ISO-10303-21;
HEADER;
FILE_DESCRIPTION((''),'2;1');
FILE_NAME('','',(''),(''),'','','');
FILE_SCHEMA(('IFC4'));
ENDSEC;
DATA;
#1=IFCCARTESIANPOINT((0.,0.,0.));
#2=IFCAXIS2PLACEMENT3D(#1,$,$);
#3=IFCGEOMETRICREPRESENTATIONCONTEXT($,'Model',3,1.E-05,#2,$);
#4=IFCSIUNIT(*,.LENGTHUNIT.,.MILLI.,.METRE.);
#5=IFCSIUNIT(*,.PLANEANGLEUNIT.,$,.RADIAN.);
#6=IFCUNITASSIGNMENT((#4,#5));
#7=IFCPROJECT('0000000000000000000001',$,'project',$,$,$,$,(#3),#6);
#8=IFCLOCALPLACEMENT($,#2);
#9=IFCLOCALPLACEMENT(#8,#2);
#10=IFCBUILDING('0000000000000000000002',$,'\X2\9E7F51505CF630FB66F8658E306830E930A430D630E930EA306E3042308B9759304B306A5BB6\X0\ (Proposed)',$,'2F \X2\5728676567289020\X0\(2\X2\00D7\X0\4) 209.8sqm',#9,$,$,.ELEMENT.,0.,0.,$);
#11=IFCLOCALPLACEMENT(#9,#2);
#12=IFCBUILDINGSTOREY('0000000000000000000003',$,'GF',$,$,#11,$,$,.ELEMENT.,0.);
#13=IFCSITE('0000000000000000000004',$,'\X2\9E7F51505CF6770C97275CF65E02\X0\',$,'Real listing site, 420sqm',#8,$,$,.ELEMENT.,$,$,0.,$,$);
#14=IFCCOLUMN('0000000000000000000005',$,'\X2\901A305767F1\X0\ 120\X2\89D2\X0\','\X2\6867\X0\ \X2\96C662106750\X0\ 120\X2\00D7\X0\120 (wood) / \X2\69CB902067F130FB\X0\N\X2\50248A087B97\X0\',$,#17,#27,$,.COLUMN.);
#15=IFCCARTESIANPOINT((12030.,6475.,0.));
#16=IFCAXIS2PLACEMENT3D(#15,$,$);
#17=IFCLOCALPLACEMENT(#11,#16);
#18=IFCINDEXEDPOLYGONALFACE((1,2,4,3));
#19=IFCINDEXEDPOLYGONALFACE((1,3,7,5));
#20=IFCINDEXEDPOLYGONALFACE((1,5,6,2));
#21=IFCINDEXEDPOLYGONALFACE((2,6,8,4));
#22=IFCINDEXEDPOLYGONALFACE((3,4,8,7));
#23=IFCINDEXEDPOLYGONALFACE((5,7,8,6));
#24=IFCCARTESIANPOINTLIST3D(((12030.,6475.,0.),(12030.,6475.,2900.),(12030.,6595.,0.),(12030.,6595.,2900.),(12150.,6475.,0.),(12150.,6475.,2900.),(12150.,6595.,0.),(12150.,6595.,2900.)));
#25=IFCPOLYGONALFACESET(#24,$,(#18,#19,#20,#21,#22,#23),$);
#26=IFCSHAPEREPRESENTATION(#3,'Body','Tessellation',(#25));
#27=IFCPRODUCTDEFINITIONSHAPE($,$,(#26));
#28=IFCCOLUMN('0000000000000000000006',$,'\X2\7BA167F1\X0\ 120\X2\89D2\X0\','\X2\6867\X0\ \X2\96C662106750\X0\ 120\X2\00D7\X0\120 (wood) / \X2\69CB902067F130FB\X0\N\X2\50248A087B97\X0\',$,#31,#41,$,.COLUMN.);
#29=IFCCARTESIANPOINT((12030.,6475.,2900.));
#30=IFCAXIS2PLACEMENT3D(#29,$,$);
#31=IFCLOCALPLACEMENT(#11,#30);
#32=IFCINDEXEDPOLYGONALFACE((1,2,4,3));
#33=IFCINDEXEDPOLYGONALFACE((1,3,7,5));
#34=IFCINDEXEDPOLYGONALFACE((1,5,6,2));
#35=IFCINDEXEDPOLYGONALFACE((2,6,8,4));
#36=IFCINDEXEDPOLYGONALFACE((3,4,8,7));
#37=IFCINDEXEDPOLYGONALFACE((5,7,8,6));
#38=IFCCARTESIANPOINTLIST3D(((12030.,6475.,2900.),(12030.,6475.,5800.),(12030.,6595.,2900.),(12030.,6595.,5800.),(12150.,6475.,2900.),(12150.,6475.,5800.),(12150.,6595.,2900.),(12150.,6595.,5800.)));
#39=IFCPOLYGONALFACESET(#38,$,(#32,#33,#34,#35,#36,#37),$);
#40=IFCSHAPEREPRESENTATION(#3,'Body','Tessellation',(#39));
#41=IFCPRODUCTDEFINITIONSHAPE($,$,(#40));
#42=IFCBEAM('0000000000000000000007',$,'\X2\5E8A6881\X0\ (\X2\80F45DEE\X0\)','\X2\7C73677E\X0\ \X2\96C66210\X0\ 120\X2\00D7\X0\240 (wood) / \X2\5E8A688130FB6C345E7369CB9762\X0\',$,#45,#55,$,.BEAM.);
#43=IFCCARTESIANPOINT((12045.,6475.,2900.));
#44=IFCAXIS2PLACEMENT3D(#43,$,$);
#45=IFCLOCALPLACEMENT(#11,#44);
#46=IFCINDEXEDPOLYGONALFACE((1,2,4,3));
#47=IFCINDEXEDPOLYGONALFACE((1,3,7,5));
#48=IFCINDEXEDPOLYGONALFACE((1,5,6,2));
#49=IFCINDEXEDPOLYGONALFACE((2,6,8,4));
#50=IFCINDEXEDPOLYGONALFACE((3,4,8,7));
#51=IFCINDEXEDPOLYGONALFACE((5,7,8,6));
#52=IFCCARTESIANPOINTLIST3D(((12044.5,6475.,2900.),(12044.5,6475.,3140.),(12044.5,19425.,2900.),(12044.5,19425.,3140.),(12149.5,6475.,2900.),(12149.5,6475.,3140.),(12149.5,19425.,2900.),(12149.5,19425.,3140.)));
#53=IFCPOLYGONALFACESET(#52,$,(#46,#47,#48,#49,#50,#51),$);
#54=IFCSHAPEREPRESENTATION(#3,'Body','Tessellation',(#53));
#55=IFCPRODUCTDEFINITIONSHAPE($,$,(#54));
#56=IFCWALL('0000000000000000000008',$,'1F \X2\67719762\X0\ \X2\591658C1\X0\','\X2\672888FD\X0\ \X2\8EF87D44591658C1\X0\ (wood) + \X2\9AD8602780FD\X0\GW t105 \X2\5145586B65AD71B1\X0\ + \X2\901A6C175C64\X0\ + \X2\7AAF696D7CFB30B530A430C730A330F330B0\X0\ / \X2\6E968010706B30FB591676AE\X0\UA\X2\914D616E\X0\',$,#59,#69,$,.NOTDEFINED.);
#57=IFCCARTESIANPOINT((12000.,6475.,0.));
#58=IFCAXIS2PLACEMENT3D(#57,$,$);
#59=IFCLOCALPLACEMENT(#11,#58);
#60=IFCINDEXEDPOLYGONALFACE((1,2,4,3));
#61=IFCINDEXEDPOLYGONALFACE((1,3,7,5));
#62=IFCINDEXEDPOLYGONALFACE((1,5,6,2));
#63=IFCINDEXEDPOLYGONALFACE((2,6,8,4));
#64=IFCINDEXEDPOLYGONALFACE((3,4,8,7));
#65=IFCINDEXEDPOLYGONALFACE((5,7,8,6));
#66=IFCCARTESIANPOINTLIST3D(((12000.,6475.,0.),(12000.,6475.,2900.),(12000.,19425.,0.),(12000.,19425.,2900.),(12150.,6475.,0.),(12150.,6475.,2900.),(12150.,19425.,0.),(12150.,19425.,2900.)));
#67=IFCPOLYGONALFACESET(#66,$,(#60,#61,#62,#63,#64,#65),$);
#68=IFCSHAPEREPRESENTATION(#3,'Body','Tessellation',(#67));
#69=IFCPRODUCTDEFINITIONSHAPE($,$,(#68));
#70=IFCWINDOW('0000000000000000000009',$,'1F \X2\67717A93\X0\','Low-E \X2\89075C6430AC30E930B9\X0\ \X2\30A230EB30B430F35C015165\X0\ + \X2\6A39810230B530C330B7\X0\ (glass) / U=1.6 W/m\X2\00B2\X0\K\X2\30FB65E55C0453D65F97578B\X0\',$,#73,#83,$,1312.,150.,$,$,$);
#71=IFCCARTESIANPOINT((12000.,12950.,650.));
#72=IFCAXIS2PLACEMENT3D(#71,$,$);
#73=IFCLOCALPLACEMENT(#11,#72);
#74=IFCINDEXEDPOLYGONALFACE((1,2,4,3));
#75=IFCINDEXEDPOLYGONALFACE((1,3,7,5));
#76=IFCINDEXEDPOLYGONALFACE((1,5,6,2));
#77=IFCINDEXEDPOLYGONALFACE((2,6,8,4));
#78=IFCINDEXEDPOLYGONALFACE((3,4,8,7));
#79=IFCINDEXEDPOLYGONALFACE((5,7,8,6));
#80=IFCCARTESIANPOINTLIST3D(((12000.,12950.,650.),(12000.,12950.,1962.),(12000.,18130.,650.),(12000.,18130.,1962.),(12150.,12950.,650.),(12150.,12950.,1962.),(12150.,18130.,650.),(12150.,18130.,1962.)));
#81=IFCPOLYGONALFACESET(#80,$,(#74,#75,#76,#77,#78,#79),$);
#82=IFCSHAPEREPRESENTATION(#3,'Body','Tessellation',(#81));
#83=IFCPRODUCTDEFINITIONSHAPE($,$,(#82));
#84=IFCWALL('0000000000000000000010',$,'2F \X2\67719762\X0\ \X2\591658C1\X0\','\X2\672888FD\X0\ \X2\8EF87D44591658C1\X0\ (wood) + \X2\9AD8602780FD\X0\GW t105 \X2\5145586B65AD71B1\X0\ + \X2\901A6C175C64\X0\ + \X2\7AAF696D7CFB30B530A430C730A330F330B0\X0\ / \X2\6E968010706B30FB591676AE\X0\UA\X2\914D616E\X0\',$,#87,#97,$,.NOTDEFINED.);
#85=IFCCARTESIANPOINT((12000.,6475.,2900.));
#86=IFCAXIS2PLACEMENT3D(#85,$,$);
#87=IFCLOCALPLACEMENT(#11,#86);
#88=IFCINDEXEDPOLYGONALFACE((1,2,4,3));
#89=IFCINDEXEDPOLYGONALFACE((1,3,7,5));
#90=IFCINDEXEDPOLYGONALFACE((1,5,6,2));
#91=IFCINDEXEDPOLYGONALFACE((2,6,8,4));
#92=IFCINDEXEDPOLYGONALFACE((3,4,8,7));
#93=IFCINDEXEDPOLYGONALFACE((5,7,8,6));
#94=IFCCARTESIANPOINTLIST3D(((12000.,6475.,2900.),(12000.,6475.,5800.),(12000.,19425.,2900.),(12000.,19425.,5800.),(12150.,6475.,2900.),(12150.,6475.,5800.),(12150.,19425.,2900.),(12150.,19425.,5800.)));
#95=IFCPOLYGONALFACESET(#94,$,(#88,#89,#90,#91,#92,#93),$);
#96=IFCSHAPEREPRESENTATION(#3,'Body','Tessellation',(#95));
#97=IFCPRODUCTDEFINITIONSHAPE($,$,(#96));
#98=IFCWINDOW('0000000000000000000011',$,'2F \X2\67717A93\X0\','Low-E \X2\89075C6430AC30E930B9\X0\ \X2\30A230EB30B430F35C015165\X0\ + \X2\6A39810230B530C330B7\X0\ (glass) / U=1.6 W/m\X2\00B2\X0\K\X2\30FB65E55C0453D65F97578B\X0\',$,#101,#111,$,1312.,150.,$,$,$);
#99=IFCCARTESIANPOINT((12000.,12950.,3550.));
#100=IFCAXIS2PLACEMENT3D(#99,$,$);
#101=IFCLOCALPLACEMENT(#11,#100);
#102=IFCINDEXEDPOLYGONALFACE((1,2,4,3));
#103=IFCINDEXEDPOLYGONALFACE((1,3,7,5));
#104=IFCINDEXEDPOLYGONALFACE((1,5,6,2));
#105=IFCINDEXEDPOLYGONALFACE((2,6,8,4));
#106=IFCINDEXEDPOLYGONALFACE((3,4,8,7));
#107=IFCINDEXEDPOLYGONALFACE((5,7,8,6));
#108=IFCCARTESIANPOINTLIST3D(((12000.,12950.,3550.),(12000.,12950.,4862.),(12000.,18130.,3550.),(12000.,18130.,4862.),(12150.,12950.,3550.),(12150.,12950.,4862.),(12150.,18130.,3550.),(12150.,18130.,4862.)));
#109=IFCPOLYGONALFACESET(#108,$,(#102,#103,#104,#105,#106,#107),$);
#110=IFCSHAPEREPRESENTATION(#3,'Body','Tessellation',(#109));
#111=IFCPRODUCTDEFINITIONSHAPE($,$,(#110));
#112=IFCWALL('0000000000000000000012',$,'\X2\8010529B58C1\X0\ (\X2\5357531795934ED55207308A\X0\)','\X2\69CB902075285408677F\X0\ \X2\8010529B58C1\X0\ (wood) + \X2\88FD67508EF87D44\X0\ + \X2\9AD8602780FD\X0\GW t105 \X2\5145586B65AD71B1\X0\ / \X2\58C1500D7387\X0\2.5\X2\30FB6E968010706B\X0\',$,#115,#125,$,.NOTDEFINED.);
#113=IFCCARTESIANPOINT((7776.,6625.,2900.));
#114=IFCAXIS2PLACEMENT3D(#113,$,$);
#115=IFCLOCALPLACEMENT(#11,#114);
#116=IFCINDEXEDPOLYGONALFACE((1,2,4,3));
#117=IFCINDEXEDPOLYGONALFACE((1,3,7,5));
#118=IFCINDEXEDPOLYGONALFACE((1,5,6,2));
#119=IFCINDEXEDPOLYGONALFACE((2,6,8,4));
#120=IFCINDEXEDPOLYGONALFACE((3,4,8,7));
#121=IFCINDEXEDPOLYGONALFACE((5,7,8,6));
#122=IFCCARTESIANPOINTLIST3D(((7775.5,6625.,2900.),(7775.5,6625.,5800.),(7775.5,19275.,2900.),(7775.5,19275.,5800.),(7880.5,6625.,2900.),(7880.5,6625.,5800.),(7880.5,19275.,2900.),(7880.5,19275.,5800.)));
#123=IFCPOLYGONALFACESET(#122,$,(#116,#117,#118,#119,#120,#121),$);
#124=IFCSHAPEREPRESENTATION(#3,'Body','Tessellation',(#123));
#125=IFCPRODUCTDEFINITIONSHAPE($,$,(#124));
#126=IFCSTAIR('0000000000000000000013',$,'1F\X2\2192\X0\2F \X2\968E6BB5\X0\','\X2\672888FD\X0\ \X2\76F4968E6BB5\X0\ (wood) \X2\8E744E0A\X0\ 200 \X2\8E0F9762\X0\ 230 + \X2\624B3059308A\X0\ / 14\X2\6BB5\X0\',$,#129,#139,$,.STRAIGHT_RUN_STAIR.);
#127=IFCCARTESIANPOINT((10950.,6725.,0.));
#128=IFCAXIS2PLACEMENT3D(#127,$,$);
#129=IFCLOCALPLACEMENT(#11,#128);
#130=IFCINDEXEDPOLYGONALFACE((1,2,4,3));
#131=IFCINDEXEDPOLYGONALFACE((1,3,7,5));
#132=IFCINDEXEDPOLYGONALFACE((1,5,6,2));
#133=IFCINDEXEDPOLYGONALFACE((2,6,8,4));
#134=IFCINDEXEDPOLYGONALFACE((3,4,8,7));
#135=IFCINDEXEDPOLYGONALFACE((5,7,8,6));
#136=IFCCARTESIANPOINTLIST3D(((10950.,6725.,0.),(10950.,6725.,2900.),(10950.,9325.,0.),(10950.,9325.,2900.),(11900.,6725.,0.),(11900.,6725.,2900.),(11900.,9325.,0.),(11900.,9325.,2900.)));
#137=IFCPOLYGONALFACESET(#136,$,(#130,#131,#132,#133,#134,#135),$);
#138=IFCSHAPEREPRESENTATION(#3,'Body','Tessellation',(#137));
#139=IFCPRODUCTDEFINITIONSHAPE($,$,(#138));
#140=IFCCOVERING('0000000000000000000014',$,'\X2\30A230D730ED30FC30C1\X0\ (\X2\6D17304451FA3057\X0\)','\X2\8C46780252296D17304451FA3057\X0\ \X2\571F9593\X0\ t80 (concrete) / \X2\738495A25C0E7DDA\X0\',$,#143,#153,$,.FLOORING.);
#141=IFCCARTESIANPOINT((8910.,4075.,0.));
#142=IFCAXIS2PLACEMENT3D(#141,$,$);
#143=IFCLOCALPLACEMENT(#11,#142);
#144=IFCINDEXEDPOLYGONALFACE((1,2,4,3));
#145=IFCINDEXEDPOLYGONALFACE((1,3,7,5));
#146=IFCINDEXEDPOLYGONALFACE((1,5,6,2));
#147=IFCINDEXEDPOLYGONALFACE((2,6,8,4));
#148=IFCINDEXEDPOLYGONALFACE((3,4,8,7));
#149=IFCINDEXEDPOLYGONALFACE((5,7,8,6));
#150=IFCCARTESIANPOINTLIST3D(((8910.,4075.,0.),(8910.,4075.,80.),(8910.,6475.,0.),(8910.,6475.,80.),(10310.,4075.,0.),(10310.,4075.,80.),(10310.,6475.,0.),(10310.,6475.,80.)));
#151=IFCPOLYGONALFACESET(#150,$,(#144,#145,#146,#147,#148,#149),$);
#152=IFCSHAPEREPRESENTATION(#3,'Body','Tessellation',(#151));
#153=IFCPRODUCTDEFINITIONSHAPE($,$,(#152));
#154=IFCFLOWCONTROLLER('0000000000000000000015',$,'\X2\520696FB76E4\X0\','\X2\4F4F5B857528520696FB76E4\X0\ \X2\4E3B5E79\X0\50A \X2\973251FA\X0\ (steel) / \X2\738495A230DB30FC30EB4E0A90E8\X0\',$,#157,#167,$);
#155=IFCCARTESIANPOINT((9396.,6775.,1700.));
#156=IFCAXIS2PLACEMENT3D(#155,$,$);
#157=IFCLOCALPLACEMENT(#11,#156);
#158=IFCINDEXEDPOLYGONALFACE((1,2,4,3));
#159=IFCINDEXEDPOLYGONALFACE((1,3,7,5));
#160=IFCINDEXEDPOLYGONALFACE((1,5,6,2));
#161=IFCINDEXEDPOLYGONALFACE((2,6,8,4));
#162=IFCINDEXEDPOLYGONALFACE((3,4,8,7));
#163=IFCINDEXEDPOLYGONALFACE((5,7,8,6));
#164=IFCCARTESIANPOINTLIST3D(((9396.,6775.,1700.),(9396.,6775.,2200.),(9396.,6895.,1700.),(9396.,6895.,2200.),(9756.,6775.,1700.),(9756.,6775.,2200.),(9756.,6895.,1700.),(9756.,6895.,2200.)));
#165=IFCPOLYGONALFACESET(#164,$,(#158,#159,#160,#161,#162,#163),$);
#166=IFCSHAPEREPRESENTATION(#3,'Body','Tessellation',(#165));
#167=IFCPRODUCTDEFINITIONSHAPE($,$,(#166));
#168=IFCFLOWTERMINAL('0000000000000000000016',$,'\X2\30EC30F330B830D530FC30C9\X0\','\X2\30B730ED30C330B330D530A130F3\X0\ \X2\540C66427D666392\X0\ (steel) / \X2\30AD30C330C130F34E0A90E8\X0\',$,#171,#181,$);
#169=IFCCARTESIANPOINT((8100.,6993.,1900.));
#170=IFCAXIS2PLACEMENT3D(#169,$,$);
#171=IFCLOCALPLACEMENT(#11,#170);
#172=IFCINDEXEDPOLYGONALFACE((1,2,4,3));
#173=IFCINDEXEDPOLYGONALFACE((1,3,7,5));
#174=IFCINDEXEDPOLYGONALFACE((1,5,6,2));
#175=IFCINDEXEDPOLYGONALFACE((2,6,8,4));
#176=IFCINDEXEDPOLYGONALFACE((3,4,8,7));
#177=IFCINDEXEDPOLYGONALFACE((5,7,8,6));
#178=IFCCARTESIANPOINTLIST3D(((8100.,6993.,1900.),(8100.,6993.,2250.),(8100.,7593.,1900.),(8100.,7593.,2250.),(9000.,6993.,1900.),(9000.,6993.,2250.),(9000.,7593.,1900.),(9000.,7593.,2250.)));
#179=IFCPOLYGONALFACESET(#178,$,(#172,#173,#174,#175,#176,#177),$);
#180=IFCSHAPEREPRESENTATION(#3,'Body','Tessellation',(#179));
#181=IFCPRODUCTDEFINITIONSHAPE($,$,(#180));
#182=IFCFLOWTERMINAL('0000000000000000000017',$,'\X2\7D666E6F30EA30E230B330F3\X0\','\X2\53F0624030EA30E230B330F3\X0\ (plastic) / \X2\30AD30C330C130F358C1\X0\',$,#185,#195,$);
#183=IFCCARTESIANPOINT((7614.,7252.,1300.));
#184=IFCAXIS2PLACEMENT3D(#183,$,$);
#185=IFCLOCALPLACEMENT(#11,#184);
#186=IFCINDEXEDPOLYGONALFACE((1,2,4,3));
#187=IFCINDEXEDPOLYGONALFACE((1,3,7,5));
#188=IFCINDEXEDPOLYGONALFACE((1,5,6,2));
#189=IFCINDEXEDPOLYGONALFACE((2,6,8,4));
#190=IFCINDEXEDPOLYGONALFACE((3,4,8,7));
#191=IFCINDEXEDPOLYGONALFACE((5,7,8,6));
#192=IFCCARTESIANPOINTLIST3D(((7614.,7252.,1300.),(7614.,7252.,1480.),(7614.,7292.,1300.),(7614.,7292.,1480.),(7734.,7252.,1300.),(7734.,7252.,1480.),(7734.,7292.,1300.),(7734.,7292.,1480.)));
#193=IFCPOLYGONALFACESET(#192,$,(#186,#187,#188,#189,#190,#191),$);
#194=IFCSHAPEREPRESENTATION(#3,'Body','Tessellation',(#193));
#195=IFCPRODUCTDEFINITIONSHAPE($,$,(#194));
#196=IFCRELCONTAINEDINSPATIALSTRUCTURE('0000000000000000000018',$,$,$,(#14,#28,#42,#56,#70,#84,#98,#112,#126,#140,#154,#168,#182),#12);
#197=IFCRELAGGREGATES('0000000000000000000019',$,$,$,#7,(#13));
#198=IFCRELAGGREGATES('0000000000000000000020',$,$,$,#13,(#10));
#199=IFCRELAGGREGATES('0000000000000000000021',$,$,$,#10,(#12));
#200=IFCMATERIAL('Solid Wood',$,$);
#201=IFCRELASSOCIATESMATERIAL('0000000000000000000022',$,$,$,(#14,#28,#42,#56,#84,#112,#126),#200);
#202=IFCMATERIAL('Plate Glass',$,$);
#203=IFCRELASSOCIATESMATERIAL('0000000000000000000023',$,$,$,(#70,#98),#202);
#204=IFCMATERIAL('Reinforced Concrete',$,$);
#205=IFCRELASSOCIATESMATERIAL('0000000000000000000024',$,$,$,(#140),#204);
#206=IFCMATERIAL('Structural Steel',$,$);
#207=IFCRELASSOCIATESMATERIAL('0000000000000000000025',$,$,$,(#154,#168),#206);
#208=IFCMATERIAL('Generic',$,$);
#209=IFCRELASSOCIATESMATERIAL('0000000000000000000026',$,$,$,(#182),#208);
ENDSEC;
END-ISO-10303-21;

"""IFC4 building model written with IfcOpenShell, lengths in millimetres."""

from ifc_helpers import new_model, si_unit, frame, frame_2d, origin, place, context, project, spatial, rectangle, extrude, material, element, fill, save


model = new_model("IFC4")

# Units and contexts
model_context = context("Model", 3, precision=1e-05, world=origin())
ifc_project = project(units=[si_unit("LENGTHUNIT", "METRE", prefix="MILLI"), si_unit("PLANEANGLEUNIT", "RADIAN")], contexts=[model_context])

# Site, building, storey
site_placement = place(None, origin())
site = spatial("IfcSite", under=ifc_project, at=site_placement, Name="鹿児島県霧島市", ObjectType="Real listing site, 420sqm", CompositionType="ELEMENT", RefElevation=0.0)
building_placement = place(site_placement, origin())
building = spatial("IfcBuilding", under=site, at=building_placement, Name="鹿児島・書斎とライブラリのある静かな家 (Proposed)", ObjectType="2F 在来木造(2×4) 209.8sqm", CompositionType="ELEMENT", ElevationOfRefHeight=0.0, ElevationOfTerrain=0.0)
storey_placement = place(building_placement, origin())
storey = spatial("IfcBuildingStorey", under=building, at=storey_placement, Name="GF", CompositionType="ELEMENT", Elevation=0.0)

# Columns
ifc_material_1 = material(Name="Solid Wood")
column_1_placement = place(storey_placement, frame((12030.0, 6475.0, 0.0)))
element("IfcColumn", 1, at=column_1_placement, inside=storey, material=ifc_material_1, Name="通し柱 120角", Description="桧 集成材 120×120 (wood) / 構造柱・N値計算", PredefinedType="COLUMN", context=model_context, shape_type="SweptSolid", body=[
    extrude(rectangle(XDim=120.0, YDim=120.0, at=frame_2d((60.0, 60.0))), frame((12030.0, 6475.0, 0.0)), (0.0, 0.0, 1.0), 2900.0),
])
column_2_placement = place(storey_placement, frame((12030.0, 6475.0, 2900.0)))
element("IfcColumn", 2, at=column_2_placement, inside=storey, material=ifc_material_1, Name="管柱 120角", Description="桧 集成材 120×120 (wood) / 構造柱・N値計算", PredefinedType="COLUMN", context=model_context, shape_type="SweptSolid", body=[
    extrude(rectangle(XDim=120.0, YDim=120.0, at=frame_2d((60.0, 60.0))), frame((12030.0, 6475.0, 2900.0)), (0.0, 0.0, 1.0), 2900.0),
])

# Beam
beam_1_placement = place(storey_placement, frame((12045.0, 6475.0, 2900.0)))
element("IfcBeam", 3, at=beam_1_placement, inside=storey, material=ifc_material_1, Name="床梁 (胴差)", Description="米松 集成 120×240 (wood) / 床梁・水平構面", PredefinedType="BEAM", context=model_context, shape_type="SweptSolid", body=[
    extrude(rectangle(XDim=105.0, YDim=12950.0, at=frame_2d((52.0, 6475.0))), frame((12045.0, 6475.0, 2900.0)), (0.0, 0.0, 1.0), 240.0),
])

# Wall, opening, window
wall_1_placement = place(storey_placement, frame((12000.0, 6475.0, 0.0)))
wall_1 = element("IfcWall", 4, at=wall_1_placement, inside=storey, material=ifc_material_1, Name="1F 東面 外壁", Description="木製 軸組外壁 (wood) + 高性能GW t105 充填断熱 + 通気層 + 窯業系サイディング / 準耐火・外皮UA配慮", PredefinedType="NOTDEFINED", context=model_context, shape_type="SweptSolid", body=[
    extrude(rectangle(XDim=150.0, YDim=12950.0, at=frame_2d((75.0, 6475.0))), frame((12000.0, 6475.0, 0.0)), (0.0, 0.0, 1.0), 2900.0),
])
opening_1_placement = place(storey_placement, frame((12000.0, 12950.0, 650.0)))
opening_1 = element("IfcOpeningElement", 5, at=opening_1_placement, cuts=wall_1, PredefinedType="NOTDEFINED", context=model_context, shape_type="SweptSolid", body=[
    extrude(rectangle(XDim=150.0, YDim=5180.0, at=frame_2d((75.0, 2590.0))), frame((12000.0, 12950.0, 650.0)), (0.0, 0.0, 1.0), 1312.0),
])
ifc_material_2 = material(Name="Plate Glass")
window_1_placement = place(storey_placement, frame((12000.0, 12950.0, 650.0)))
window_1 = element("IfcWindow", 6, at=window_1_placement, inside=storey, material=ifc_material_2, Name="1F 東窓", Description="Low-E 複層ガラス アルゴン封入 + 樹脂サッシ (glass) / U=1.6 W/m²K・日射取得型", OverallHeight=1312.0, OverallWidth=150.0, context=model_context, shape_type="SweptSolid", body=[
    extrude(rectangle(XDim=150.0, YDim=5180.0, at=frame_2d((75.0, 2590.0))), frame((12000.0, 12950.0, 650.0)), (0.0, 0.0, 1.0), 1312.0),
])
fill(opening_1, window_1)

# Wall, opening, window
wall_2_placement = place(storey_placement, frame((12000.0, 6475.0, 2900.0)))
wall_2 = element("IfcWall", 7, at=wall_2_placement, inside=storey, material=ifc_material_1, Name="2F 東面 外壁", Description="木製 軸組外壁 (wood) + 高性能GW t105 充填断熱 + 通気層 + 窯業系サイディング / 準耐火・外皮UA配慮", PredefinedType="NOTDEFINED", context=model_context, shape_type="SweptSolid", body=[
    extrude(rectangle(XDim=150.0, YDim=12950.0, at=frame_2d((75.0, 6475.0))), frame((12000.0, 6475.0, 2900.0)), (0.0, 0.0, 1.0), 2900.0),
])
opening_2_placement = place(storey_placement, frame((12000.0, 12950.0, 3550.0)))
opening_2 = element("IfcOpeningElement", 8, at=opening_2_placement, cuts=wall_2, PredefinedType="NOTDEFINED", context=model_context, shape_type="SweptSolid", body=[
    extrude(rectangle(XDim=150.0, YDim=5180.0, at=frame_2d((75.0, 2590.0))), frame((12000.0, 12950.0, 3550.0)), (0.0, 0.0, 1.0), 1312.0),
])
window_2_placement = place(storey_placement, frame((12000.0, 12950.0, 3550.0)))
window_2 = element("IfcWindow", 9, at=window_2_placement, inside=storey, material=ifc_material_2, Name="2F 東窓", Description="Low-E 複層ガラス アルゴン封入 + 樹脂サッシ (glass) / U=1.6 W/m²K・日射取得型", OverallHeight=1312.0, OverallWidth=150.0, context=model_context, shape_type="SweptSolid", body=[
    extrude(rectangle(XDim=150.0, YDim=5180.0, at=frame_2d((75.0, 2590.0))), frame((12000.0, 12950.0, 3550.0)), (0.0, 0.0, 1.0), 1312.0),
])
fill(opening_2, window_2)

# Wall
wall_3_placement = place(storey_placement, frame((7776.0, 6625.0, 2900.0)))
element("IfcWall", 10, at=wall_3_placement, inside=storey, material=ifc_material_1, Name="耐力壁 (南北間仕切り)", Description="構造用合板 耐力壁 (wood) + 製材軸組 + 高性能GW t105 充填断熱 / 壁倍率2.5・準耐火", PredefinedType="NOTDEFINED", context=model_context, shape_type="SweptSolid", body=[
    extrude(rectangle(XDim=105.0, YDim=12650.0, at=frame_2d((52.0, 6325.0))), frame((7776.0, 6625.0, 2900.0)), (0.0, 0.0, 1.0), 2900.0),
])

# Stair
stair_placement = place(storey_placement, frame((10950.0, 6725.0, 0.0)))
element("IfcStair", 11, at=stair_placement, inside=storey, material=ifc_material_1, Name="1F→2F 階段", Description="木製 直階段 (wood) 蹴上 200 踏面 230 + 手すり / 14段", PredefinedType="STRAIGHT_RUN_STAIR", context=model_context, shape_type="SweptSolid", body=[
    extrude(rectangle(XDim=950.0, YDim=2600.0, at=frame_2d((475.0, 1300.0))), frame((10950.0, 6725.0, 0.0)), (0.0, 0.0, 1.0), 2900.0),
])

# Covering
ifc_material_3 = material(Name="Reinforced Concrete")
covering_placement = place(storey_placement, frame((8910.0, 4075.0, 0.0)))
element("IfcCovering", 12, at=covering_placement, inside=storey, material=ifc_material_3, Name="アプローチ (洗い出し)", Description="豆砂利洗い出し 土間 t80 (concrete) / 玄関導線", PredefinedType="FLOORING", context=model_context, shape_type="SweptSolid", body=[
    extrude(rectangle(XDim=1400.0, YDim=2400.0, at=frame_2d((700.0, 1200.0))), frame((8910.0, 4075.0, 0.0)), (0.0, 0.0, 1.0), 80.0),
])

# Flow controller
ifc_material_4 = material(Name="Structural Steel")
flow_controller_placement = place(storey_placement, frame((9396.0, 6775.0, 1700.0)))
element("IfcFlowController", 13, at=flow_controller_placement, inside=storey, material=ifc_material_4, Name="分電盤", Description="住宅用分電盤 主幹50A 露出 (steel) / 玄関ホール上部", context=model_context, shape_type="SweptSolid", body=[
    extrude(rectangle(XDim=360.0, YDim=120.0, at=frame_2d((180.0, 60.0))), frame((9396.0, 6775.0, 1700.0)), (0.0, 0.0, 1.0), 500.0),
])

# Flow terminals
flow_terminal_1_placement = place(storey_placement, frame((8100.0, 6993.0, 1900.0)))
element("IfcFlowTerminal", 14, at=flow_terminal_1_placement, inside=storey, material=ifc_material_4, Name="レンジフード", Description="シロッコファン 同時給排 (steel) / キッチン上部", context=model_context, shape_type="SweptSolid", body=[
    extrude(rectangle(XDim=900.0, YDim=600.0, at=frame_2d((450.0, 300.0))), frame((8100.0, 6993.0, 1900.0)), (0.0, 0.0, 1.0), 350.0),
])
ifc_material_5 = material(Name="Generic")
flow_terminal_2_placement = place(storey_placement, frame((7614.0, 7252.0, 1300.0)))
element("IfcFlowTerminal", 15, at=flow_terminal_2_placement, inside=storey, material=ifc_material_5, Name="給湯リモコン", Description="台所リモコン (plastic) / キッチン壁", context=model_context, shape_type="SweptSolid", body=[
    extrude(rectangle(XDim=120.0, YDim=40.0, at=frame_2d((60.0, 20.0))), frame((7614.0, 7252.0, 1300.0)), (0.0, 0.0, 1.0), 180.0),
])

save(model, "model.ifc")
